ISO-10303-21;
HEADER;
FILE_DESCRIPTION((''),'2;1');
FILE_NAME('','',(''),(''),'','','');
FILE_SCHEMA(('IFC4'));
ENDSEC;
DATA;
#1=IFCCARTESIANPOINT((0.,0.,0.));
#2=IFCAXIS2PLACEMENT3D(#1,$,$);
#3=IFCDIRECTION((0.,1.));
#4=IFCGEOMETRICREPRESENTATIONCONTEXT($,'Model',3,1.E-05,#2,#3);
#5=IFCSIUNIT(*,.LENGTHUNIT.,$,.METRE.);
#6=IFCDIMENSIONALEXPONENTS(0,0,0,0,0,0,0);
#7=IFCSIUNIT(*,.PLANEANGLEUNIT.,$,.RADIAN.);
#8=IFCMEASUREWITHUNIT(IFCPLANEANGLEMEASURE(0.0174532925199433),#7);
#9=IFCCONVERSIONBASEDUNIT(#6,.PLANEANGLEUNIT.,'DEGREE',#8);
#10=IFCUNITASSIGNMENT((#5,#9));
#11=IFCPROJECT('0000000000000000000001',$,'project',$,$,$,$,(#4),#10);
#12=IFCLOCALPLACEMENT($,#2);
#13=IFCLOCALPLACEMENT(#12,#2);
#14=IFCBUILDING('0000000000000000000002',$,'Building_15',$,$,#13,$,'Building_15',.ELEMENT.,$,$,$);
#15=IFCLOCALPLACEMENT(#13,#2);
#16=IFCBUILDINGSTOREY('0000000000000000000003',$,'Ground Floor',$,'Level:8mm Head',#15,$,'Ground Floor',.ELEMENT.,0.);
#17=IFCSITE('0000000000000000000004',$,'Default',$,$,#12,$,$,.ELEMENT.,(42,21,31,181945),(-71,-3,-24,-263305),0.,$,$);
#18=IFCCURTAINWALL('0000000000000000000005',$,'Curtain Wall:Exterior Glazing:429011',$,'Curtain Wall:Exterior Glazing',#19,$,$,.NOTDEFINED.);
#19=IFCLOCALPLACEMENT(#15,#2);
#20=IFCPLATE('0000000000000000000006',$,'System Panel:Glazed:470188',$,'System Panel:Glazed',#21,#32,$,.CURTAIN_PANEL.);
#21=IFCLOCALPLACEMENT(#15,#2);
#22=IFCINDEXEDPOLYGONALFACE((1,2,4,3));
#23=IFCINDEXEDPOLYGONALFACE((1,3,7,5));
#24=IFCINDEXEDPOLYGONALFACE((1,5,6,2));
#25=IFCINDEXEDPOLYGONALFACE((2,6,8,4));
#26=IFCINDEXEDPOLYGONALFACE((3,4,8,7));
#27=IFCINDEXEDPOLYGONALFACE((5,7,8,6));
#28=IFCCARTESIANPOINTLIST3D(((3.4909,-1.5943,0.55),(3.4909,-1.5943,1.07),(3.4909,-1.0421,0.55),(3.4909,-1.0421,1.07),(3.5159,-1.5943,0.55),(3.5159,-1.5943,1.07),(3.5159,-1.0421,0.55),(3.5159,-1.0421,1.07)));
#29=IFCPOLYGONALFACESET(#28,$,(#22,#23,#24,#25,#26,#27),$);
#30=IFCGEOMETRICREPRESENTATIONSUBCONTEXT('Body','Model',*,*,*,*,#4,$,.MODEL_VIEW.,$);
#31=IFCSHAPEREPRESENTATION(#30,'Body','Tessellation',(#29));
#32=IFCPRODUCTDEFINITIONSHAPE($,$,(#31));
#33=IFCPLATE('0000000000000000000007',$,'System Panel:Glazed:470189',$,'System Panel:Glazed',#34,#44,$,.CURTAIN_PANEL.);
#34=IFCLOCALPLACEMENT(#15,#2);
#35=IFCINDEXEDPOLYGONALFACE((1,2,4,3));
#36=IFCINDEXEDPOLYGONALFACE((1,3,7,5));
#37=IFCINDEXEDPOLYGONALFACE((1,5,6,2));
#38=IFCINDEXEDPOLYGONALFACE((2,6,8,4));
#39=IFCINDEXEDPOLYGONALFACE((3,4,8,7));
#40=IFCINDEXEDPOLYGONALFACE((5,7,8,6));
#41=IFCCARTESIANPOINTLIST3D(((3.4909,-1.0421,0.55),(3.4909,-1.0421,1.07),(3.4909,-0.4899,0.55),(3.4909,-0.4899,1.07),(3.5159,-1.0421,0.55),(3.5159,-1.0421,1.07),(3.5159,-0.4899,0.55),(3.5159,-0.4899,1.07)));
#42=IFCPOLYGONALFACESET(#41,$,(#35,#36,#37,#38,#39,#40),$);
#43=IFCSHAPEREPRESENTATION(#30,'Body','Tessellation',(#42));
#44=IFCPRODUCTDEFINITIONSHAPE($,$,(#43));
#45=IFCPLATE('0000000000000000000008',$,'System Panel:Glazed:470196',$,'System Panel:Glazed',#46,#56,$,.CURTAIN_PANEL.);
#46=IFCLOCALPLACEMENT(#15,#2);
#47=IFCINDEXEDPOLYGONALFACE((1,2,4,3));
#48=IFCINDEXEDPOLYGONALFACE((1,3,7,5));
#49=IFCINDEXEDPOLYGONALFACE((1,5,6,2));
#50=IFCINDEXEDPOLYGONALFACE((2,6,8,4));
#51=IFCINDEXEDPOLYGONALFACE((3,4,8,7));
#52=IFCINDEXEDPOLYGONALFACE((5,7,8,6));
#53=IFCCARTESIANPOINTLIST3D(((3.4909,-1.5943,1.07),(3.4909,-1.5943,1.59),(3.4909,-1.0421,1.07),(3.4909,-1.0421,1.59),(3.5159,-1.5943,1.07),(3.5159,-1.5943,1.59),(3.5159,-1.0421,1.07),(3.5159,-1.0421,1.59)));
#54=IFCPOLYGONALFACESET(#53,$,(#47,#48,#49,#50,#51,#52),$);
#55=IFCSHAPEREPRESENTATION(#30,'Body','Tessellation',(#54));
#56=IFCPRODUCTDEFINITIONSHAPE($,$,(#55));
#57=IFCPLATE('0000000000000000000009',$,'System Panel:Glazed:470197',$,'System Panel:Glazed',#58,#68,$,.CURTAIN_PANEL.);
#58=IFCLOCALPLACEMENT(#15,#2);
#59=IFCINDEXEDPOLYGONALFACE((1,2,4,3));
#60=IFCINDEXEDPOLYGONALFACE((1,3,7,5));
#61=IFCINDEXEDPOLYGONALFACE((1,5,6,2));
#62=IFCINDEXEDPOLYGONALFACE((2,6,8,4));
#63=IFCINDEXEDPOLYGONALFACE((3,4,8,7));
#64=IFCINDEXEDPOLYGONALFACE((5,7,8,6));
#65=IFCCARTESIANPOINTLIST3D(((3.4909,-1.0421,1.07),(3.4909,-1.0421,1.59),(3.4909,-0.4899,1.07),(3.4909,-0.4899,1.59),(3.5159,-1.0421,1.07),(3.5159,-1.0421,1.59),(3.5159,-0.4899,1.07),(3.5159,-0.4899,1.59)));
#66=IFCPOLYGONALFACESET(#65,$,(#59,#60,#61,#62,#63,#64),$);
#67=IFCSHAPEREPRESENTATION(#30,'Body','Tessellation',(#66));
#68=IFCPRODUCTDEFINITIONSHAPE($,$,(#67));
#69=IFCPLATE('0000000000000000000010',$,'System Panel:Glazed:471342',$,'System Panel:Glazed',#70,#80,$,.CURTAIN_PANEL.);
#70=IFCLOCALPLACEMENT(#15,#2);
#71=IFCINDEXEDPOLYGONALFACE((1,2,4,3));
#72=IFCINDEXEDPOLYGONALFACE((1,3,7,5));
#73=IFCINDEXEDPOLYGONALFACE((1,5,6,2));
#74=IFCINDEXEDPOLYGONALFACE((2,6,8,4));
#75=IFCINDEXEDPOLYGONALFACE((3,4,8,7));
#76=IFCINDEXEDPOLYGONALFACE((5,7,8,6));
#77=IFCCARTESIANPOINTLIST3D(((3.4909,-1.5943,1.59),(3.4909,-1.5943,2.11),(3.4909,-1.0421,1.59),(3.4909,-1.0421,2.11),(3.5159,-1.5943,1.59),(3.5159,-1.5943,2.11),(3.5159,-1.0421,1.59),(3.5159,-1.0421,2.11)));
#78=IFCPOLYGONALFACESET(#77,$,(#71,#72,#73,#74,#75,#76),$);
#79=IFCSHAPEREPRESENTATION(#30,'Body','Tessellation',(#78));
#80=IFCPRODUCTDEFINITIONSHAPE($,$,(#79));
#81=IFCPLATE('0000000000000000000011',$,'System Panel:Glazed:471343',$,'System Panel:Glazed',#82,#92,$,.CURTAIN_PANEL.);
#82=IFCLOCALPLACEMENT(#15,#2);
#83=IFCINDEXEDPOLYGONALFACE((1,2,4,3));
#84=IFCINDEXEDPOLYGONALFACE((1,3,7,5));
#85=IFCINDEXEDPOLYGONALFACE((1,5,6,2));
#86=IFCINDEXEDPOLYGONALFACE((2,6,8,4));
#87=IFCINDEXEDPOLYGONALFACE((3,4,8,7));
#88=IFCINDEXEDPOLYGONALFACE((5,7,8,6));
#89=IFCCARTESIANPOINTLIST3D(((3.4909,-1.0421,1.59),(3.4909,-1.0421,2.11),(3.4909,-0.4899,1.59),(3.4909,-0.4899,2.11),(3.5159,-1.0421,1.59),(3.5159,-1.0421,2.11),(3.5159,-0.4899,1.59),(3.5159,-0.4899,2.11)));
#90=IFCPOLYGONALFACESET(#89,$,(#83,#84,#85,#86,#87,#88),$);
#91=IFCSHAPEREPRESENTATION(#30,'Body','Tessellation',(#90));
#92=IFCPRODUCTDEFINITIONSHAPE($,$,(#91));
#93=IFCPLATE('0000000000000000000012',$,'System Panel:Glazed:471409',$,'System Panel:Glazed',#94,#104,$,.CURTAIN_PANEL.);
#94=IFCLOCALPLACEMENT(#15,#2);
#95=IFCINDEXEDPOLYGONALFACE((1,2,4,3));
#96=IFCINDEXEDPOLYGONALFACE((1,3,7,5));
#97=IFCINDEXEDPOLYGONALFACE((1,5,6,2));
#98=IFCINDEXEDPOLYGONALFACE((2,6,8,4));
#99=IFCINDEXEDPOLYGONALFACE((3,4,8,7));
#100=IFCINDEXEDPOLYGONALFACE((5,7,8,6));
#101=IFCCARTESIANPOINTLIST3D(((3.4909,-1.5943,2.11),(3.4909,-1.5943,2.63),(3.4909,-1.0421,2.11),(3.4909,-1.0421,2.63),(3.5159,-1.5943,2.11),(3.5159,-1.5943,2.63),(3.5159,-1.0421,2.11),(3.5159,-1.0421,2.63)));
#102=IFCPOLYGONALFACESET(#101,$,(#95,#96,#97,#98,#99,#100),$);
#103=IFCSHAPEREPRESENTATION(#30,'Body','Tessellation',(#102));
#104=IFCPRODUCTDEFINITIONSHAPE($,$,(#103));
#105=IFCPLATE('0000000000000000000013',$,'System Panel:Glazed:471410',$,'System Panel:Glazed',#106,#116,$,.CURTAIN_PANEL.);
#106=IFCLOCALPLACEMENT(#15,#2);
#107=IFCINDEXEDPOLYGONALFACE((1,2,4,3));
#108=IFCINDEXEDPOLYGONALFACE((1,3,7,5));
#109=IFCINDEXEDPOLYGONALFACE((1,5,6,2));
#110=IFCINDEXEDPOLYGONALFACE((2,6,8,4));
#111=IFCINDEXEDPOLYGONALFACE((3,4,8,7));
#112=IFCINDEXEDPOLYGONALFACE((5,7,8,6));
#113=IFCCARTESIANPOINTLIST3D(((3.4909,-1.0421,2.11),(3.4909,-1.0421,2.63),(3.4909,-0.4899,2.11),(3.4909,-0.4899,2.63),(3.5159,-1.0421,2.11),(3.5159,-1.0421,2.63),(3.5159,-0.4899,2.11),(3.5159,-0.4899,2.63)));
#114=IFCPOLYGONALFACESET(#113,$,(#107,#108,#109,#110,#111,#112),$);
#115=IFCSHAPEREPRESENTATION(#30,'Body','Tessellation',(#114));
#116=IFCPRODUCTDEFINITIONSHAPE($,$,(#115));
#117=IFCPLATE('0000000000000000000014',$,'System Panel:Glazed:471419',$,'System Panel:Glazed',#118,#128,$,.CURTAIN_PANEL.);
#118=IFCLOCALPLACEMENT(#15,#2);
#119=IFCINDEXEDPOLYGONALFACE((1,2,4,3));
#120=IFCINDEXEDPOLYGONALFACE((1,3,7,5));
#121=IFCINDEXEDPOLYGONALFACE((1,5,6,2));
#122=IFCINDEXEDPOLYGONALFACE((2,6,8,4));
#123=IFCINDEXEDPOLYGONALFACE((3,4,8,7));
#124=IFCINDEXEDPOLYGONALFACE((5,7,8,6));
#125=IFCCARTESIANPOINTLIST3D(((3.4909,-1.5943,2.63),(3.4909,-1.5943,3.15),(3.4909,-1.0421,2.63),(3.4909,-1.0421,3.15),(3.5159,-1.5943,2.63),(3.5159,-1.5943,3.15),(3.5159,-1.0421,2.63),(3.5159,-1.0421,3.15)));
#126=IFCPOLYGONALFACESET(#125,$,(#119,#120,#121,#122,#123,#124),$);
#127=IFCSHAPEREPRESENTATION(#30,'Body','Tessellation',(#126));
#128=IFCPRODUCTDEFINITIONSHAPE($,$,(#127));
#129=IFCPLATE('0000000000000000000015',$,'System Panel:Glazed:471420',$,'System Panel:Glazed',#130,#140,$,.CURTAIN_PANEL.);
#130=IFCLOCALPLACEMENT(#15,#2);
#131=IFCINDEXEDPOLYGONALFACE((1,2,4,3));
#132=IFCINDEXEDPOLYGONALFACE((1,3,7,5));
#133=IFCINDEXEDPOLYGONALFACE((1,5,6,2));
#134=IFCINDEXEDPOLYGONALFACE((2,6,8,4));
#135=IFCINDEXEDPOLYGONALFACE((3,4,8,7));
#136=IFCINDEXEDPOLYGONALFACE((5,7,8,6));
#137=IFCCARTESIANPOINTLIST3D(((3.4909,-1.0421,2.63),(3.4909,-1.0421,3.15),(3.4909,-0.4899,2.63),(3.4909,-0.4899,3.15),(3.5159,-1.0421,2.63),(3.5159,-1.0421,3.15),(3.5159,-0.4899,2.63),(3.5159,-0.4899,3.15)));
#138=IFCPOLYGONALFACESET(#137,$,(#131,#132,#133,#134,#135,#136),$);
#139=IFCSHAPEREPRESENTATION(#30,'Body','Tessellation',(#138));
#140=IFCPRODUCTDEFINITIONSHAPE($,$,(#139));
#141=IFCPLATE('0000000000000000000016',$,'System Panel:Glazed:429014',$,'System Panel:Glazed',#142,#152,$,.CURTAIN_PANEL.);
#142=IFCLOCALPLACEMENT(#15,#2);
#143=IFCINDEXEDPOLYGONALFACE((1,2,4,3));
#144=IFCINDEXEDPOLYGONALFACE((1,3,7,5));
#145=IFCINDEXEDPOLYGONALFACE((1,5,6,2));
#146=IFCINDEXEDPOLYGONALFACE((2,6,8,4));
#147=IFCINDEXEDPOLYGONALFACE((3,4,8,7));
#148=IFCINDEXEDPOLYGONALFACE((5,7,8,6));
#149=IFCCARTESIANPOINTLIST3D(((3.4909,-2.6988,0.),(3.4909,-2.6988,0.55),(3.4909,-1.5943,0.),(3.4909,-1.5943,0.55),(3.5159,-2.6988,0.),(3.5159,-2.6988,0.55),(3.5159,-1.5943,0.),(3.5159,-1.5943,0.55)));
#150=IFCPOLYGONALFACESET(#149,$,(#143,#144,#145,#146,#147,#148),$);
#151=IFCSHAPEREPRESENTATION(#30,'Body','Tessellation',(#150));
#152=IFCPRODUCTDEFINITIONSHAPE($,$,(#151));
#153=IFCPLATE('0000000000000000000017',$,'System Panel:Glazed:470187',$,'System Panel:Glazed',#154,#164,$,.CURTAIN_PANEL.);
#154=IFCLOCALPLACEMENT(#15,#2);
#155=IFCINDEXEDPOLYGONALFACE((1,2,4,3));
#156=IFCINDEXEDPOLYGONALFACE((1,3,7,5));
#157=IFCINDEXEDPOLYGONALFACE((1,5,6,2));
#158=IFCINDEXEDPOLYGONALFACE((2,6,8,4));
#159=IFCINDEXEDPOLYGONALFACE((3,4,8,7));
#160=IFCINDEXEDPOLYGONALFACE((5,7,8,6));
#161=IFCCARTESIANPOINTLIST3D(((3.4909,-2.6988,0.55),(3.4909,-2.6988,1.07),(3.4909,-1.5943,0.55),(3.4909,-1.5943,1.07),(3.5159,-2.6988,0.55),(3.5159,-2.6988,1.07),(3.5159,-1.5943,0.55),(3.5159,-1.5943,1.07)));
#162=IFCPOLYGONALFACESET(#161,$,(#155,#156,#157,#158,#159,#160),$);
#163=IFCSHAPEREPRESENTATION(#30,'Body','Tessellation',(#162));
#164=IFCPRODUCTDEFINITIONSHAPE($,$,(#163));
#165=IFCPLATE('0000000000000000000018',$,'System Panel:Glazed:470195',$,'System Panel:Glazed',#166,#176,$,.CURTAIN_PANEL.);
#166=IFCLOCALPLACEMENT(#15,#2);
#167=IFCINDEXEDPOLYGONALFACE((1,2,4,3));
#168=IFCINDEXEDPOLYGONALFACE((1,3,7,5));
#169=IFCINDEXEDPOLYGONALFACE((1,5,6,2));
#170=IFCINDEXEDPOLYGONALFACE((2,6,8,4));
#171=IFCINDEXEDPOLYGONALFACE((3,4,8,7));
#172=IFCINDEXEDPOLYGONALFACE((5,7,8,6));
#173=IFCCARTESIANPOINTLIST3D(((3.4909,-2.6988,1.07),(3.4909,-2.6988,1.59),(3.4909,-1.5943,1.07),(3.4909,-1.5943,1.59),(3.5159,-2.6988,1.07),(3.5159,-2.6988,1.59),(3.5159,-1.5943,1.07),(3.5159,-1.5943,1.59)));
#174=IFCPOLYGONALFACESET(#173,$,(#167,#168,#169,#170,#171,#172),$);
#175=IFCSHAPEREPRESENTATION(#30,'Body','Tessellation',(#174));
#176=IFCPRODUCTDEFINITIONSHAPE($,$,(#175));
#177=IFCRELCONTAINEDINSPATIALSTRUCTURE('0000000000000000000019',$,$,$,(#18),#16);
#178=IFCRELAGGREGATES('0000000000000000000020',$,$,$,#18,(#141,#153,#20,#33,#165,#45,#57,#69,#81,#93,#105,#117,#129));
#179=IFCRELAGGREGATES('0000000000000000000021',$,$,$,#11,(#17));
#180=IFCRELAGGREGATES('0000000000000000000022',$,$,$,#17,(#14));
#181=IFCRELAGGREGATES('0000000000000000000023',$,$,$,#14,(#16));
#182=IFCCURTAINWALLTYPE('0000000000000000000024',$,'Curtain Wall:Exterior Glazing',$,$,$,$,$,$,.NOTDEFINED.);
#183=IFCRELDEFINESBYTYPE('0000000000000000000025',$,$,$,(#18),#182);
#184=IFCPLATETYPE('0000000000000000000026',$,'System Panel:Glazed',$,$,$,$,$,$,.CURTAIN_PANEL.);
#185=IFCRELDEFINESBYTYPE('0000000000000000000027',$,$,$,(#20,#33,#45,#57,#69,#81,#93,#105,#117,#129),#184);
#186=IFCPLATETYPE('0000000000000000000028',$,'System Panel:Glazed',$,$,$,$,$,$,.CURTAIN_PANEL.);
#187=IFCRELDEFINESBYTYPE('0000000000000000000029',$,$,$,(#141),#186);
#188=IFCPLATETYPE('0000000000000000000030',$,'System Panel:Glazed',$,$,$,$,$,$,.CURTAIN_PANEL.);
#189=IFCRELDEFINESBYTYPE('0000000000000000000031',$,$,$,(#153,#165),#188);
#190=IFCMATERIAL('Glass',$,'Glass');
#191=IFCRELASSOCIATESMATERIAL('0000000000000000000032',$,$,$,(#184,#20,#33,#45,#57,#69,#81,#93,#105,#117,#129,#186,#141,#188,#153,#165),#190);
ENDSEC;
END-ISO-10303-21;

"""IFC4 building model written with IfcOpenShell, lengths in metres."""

from ifc_helpers import new_model, entity, si_unit, converted_unit, direction, frame, origin, place, context, subcontext, project, spatial, indexed_curve, outline, extrude, source, transform, mapped, material, type_object, type_shapes, element, aggregate, save


model = new_model("IFC4")

# Units and contexts
model_context = context("Model", 3, precision=1e-05, world=origin(), true_north=direction((0.0, 1.0)))
body_context = subcontext(model_context, "Body", "Model", "MODEL_VIEW")
ifc_project = project(units=[si_unit("LENGTHUNIT", "METRE"), converted_unit("PLANEANGLEUNIT", "DEGREE", entity("IfcPlaneAngleMeasure", 0.0174532925199433), si_unit("PLANEANGLEUNIT", "RADIAN"), dimensions=[0, 0, 0, 0, 0, 0, 0])], contexts=[model_context])

# Site, building, storey
site_placement = place(None, origin())
site = spatial("IfcSite", under=ifc_project, at=site_placement, Name="Default", CompositionType="ELEMENT", RefLatitude=(42, 21, 31, 181945), RefLongitude=(-71, -3, -24, -263305), RefElevation=0.0)
building_placement = place(site_placement, origin())
building = spatial("IfcBuilding", under=site, at=building_placement, Name="Building_15", LongName="Building_15", CompositionType="ELEMENT")
storey_placement = place(building_placement, origin())
storey = spatial("IfcBuildingStorey", under=building, at=storey_placement, Name="Ground Floor", ObjectType="Level:8mm Head", LongName="Ground Floor", CompositionType="ELEMENT", Elevation=0.0)

# Curtain wall, plates
curtain_wall_type = type_object("IfcCurtainWallType", Name="Curtain Wall:Exterior Glazing", PredefinedType="NOTDEFINED")
curtain_wall_placement = place(storey_placement, origin())
curtain_wall = element("IfcCurtainWall", 1, at=curtain_wall_placement, inside=storey, type_object=curtain_wall_type, Name="Curtain Wall:Exterior Glazing:429011", ObjectType="Curtain Wall:Exterior Glazing", PredefinedType="NOTDEFINED")
ifc_material_1 = material(Name="Glass", Category="Glass")
plate_type_1 = type_object("IfcPlateType", Name="System Panel:Glazed", PredefinedType="CURTAIN_PANEL", material=ifc_material_1)
shared_shape_1 = source(origin(), body_context, "Body", "SweptSolid", [
    extrude(outline(indexed_curve([(-0.0125, -0.2761), (0.0125, -0.2761), (0.0125, 0.2761), (-0.0125, 0.2761), (-0.0125, -0.2761)], self_intersect=False)), frame((0.0, 0.037, 0.0), z_axis=(0.0, 0.0, 1.0), x_axis=(0.0, 1.0, 0.0)), (0.0, 0.0, 1.0), 0.52),
])
type_shapes(plate_type_1, [shared_shape_1])
plate_1_placement = place(curtain_wall_placement, frame((3.5404, -1.3182, 0.55), z_axis=(0.0, 0.0, 1.0), x_axis=(0.0, 1.0, 0.0)))
plate_1 = element("IfcPlate", 2, at=plate_1_placement, type_object=plate_type_1, material=ifc_material_1, Name="System Panel:Glazed:470188", ObjectType="System Panel:Glazed", PredefinedType="CURTAIN_PANEL", context=body_context, shape_type="MappedRepresentation", body=[
    mapped(shared_shape_1, transform((0.0, 0.0, 0.0), scale=1.0)),
])
plate_2_placement = place(curtain_wall_placement, frame((3.5404, -0.766, 0.55), z_axis=(0.0, 0.0, 1.0), x_axis=(0.0, 1.0, 0.0)))
plate_2 = element("IfcPlate", 3, at=plate_2_placement, type_object=plate_type_1, material=ifc_material_1, Name="System Panel:Glazed:470189", ObjectType="System Panel:Glazed", PredefinedType="CURTAIN_PANEL", context=body_context, shape_type="MappedRepresentation", body=[
    mapped(shared_shape_1, transform((0.0, 0.0, 0.0), scale=1.0)),
])
plate_3_placement = place(curtain_wall_placement, frame((3.5404, -1.3182, 1.07), z_axis=(0.0, 0.0, 1.0), x_axis=(0.0, 1.0, 0.0)))
plate_3 = element("IfcPlate", 4, at=plate_3_placement, type_object=plate_type_1, material=ifc_material_1, Name="System Panel:Glazed:470196", ObjectType="System Panel:Glazed", PredefinedType="CURTAIN_PANEL", context=body_context, shape_type="MappedRepresentation", body=[
    mapped(shared_shape_1, transform((0.0, 0.0, 0.0), scale=1.0)),
])
plate_4_placement = place(curtain_wall_placement, frame((3.5404, -0.766, 1.07), z_axis=(0.0, 0.0, 1.0), x_axis=(0.0, 1.0, 0.0)))
plate_4 = element("IfcPlate", 5, at=plate_4_placement, type_object=plate_type_1, material=ifc_material_1, Name="System Panel:Glazed:470197", ObjectType="System Panel:Glazed", PredefinedType="CURTAIN_PANEL", context=body_context, shape_type="MappedRepresentation", body=[
    mapped(shared_shape_1, transform((0.0, 0.0, 0.0), scale=1.0)),
])
plate_5_placement = place(curtain_wall_placement, frame((3.5404, -1.3182, 1.59), z_axis=(0.0, 0.0, 1.0), x_axis=(0.0, 1.0, 0.0)))
plate_5 = element("IfcPlate", 6, at=plate_5_placement, type_object=plate_type_1, material=ifc_material_1, Name="System Panel:Glazed:471342", ObjectType="System Panel:Glazed", PredefinedType="CURTAIN_PANEL", context=body_context, shape_type="MappedRepresentation", body=[
    mapped(shared_shape_1, transform((0.0, 0.0, 0.0), scale=1.0)),
])
plate_6_placement = place(curtain_wall_placement, frame((3.5404, -0.766, 1.59), z_axis=(0.0, 0.0, 1.0), x_axis=(0.0, 1.0, 0.0)))
plate_6 = element("IfcPlate", 7, at=plate_6_placement, type_object=plate_type_1, material=ifc_material_1, Name="System Panel:Glazed:471343", ObjectType="System Panel:Glazed", PredefinedType="CURTAIN_PANEL", context=body_context, shape_type="MappedRepresentation", body=[
    mapped(shared_shape_1, transform((0.0, 0.0, 0.0), scale=1.0)),
])
plate_7_placement = place(curtain_wall_placement, frame((3.5404, -1.3182, 2.11), z_axis=(0.0, 0.0, 1.0), x_axis=(0.0, 1.0, 0.0)))
plate_7 = element("IfcPlate", 8, at=plate_7_placement, type_object=plate_type_1, material=ifc_material_1, Name="System Panel:Glazed:471409", ObjectType="System Panel:Glazed", PredefinedType="CURTAIN_PANEL", context=body_context, shape_type="MappedRepresentation", body=[
    mapped(shared_shape_1, transform((0.0, 0.0, 0.0), scale=1.0)),
])
plate_8_placement = place(curtain_wall_placement, frame((3.5404, -0.766, 2.11), z_axis=(0.0, 0.0, 1.0), x_axis=(0.0, 1.0, 0.0)))
plate_8 = element("IfcPlate", 9, at=plate_8_placement, type_object=plate_type_1, material=ifc_material_1, Name="System Panel:Glazed:471410", ObjectType="System Panel:Glazed", PredefinedType="CURTAIN_PANEL", context=body_context, shape_type="MappedRepresentation", body=[
    mapped(shared_shape_1, transform((0.0, 0.0, 0.0), scale=1.0)),
])
plate_9_placement = place(curtain_wall_placement, frame((3.5404, -1.3182, 2.63), z_axis=(0.0, 0.0, 1.0), x_axis=(0.0, 1.0, 0.0)))
plate_9 = element("IfcPlate", 10, at=plate_9_placement, type_object=plate_type_1, material=ifc_material_1, Name="System Panel:Glazed:471419", ObjectType="System Panel:Glazed", PredefinedType="CURTAIN_PANEL", context=body_context, shape_type="MappedRepresentation", body=[
    mapped(shared_shape_1, transform((0.0, 0.0, 0.0), scale=1.0)),
])
plate_10_placement = place(curtain_wall_placement, frame((3.5404, -0.766, 2.63), z_axis=(0.0, 0.0, 1.0), x_axis=(0.0, 1.0, 0.0)))
plate_10 = element("IfcPlate", 11, at=plate_10_placement, type_object=plate_type_1, material=ifc_material_1, Name="System Panel:Glazed:471420", ObjectType="System Panel:Glazed", PredefinedType="CURTAIN_PANEL", context=body_context, shape_type="MappedRepresentation", body=[
    mapped(shared_shape_1, transform((0.0, 0.0, 0.0), scale=1.0)),
])
plate_type_2 = type_object("IfcPlateType", Name="System Panel:Glazed", PredefinedType="CURTAIN_PANEL", material=ifc_material_1)
shared_shape_2 = source(origin(), body_context, "Body", "SweptSolid", [
    extrude(outline(indexed_curve([(-0.0125, -0.5522), (0.0125, -0.5522), (0.0125, 0.5522), (-0.0125, 0.5522), (-0.0125, -0.5522)], self_intersect=False)), frame((0.0, 0.037, 0.0), z_axis=(0.0, 0.0, 1.0), x_axis=(0.0, 1.0, 0.0)), (0.0, 0.0, 1.0), 0.55),
])
type_shapes(plate_type_2, [shared_shape_2])
plate_11_placement = place(curtain_wall_placement, frame((3.5404, -2.1466, 0.0), z_axis=(0.0, 0.0, 1.0), x_axis=(0.0, 1.0, 0.0)))
plate_11 = element("IfcPlate", 12, at=plate_11_placement, type_object=plate_type_2, material=ifc_material_1, Name="System Panel:Glazed:429014", ObjectType="System Panel:Glazed", PredefinedType="CURTAIN_PANEL", context=body_context, shape_type="MappedRepresentation", body=[
    mapped(shared_shape_2, transform((0.0, 0.0, 0.0), scale=1.0)),
])
plate_type_3 = type_object("IfcPlateType", Name="System Panel:Glazed", PredefinedType="CURTAIN_PANEL", material=ifc_material_1)
shared_shape_3 = source(origin(), body_context, "Body", "SweptSolid", [
    extrude(outline(indexed_curve([(-0.0125, -0.5522), (0.0125, -0.5522), (0.0125, 0.5522), (-0.0125, 0.5522), (-0.0125, -0.5522)], self_intersect=False)), frame((0.0, 0.037, 0.0), z_axis=(0.0, 0.0, 1.0), x_axis=(0.0, 1.0, 0.0)), (0.0, 0.0, 1.0), 0.52),
])
type_shapes(plate_type_3, [shared_shape_3])
plate_12_placement = place(curtain_wall_placement, frame((3.5404, -2.1466, 0.55), z_axis=(0.0, 0.0, 1.0), x_axis=(0.0, 1.0, 0.0)))
plate_12 = element("IfcPlate", 13, at=plate_12_placement, type_object=plate_type_3, material=ifc_material_1, Name="System Panel:Glazed:470187", ObjectType="System Panel:Glazed", PredefinedType="CURTAIN_PANEL", context=body_context, shape_type="MappedRepresentation", body=[
    mapped(shared_shape_3, transform((0.0, 0.0, 0.0), scale=1.0)),
])
plate_13_placement = place(curtain_wall_placement, frame((3.5404, -2.1466, 1.07), z_axis=(0.0, 0.0, 1.0), x_axis=(0.0, 1.0, 0.0)))
plate_13 = element("IfcPlate", 14, at=plate_13_placement, type_object=plate_type_3, material=ifc_material_1, Name="System Panel:Glazed:470195", ObjectType="System Panel:Glazed", PredefinedType="CURTAIN_PANEL", context=body_context, shape_type="MappedRepresentation", body=[
    mapped(shared_shape_3, transform((0.0, 0.0, 0.0), scale=1.0)),
])
aggregate(curtain_wall, [plate_11, plate_12, plate_1, plate_2, plate_13, plate_3, plate_4, plate_5, plate_6, plate_7, plate_8, plate_9, plate_10])

save(model, "model.ifc")
